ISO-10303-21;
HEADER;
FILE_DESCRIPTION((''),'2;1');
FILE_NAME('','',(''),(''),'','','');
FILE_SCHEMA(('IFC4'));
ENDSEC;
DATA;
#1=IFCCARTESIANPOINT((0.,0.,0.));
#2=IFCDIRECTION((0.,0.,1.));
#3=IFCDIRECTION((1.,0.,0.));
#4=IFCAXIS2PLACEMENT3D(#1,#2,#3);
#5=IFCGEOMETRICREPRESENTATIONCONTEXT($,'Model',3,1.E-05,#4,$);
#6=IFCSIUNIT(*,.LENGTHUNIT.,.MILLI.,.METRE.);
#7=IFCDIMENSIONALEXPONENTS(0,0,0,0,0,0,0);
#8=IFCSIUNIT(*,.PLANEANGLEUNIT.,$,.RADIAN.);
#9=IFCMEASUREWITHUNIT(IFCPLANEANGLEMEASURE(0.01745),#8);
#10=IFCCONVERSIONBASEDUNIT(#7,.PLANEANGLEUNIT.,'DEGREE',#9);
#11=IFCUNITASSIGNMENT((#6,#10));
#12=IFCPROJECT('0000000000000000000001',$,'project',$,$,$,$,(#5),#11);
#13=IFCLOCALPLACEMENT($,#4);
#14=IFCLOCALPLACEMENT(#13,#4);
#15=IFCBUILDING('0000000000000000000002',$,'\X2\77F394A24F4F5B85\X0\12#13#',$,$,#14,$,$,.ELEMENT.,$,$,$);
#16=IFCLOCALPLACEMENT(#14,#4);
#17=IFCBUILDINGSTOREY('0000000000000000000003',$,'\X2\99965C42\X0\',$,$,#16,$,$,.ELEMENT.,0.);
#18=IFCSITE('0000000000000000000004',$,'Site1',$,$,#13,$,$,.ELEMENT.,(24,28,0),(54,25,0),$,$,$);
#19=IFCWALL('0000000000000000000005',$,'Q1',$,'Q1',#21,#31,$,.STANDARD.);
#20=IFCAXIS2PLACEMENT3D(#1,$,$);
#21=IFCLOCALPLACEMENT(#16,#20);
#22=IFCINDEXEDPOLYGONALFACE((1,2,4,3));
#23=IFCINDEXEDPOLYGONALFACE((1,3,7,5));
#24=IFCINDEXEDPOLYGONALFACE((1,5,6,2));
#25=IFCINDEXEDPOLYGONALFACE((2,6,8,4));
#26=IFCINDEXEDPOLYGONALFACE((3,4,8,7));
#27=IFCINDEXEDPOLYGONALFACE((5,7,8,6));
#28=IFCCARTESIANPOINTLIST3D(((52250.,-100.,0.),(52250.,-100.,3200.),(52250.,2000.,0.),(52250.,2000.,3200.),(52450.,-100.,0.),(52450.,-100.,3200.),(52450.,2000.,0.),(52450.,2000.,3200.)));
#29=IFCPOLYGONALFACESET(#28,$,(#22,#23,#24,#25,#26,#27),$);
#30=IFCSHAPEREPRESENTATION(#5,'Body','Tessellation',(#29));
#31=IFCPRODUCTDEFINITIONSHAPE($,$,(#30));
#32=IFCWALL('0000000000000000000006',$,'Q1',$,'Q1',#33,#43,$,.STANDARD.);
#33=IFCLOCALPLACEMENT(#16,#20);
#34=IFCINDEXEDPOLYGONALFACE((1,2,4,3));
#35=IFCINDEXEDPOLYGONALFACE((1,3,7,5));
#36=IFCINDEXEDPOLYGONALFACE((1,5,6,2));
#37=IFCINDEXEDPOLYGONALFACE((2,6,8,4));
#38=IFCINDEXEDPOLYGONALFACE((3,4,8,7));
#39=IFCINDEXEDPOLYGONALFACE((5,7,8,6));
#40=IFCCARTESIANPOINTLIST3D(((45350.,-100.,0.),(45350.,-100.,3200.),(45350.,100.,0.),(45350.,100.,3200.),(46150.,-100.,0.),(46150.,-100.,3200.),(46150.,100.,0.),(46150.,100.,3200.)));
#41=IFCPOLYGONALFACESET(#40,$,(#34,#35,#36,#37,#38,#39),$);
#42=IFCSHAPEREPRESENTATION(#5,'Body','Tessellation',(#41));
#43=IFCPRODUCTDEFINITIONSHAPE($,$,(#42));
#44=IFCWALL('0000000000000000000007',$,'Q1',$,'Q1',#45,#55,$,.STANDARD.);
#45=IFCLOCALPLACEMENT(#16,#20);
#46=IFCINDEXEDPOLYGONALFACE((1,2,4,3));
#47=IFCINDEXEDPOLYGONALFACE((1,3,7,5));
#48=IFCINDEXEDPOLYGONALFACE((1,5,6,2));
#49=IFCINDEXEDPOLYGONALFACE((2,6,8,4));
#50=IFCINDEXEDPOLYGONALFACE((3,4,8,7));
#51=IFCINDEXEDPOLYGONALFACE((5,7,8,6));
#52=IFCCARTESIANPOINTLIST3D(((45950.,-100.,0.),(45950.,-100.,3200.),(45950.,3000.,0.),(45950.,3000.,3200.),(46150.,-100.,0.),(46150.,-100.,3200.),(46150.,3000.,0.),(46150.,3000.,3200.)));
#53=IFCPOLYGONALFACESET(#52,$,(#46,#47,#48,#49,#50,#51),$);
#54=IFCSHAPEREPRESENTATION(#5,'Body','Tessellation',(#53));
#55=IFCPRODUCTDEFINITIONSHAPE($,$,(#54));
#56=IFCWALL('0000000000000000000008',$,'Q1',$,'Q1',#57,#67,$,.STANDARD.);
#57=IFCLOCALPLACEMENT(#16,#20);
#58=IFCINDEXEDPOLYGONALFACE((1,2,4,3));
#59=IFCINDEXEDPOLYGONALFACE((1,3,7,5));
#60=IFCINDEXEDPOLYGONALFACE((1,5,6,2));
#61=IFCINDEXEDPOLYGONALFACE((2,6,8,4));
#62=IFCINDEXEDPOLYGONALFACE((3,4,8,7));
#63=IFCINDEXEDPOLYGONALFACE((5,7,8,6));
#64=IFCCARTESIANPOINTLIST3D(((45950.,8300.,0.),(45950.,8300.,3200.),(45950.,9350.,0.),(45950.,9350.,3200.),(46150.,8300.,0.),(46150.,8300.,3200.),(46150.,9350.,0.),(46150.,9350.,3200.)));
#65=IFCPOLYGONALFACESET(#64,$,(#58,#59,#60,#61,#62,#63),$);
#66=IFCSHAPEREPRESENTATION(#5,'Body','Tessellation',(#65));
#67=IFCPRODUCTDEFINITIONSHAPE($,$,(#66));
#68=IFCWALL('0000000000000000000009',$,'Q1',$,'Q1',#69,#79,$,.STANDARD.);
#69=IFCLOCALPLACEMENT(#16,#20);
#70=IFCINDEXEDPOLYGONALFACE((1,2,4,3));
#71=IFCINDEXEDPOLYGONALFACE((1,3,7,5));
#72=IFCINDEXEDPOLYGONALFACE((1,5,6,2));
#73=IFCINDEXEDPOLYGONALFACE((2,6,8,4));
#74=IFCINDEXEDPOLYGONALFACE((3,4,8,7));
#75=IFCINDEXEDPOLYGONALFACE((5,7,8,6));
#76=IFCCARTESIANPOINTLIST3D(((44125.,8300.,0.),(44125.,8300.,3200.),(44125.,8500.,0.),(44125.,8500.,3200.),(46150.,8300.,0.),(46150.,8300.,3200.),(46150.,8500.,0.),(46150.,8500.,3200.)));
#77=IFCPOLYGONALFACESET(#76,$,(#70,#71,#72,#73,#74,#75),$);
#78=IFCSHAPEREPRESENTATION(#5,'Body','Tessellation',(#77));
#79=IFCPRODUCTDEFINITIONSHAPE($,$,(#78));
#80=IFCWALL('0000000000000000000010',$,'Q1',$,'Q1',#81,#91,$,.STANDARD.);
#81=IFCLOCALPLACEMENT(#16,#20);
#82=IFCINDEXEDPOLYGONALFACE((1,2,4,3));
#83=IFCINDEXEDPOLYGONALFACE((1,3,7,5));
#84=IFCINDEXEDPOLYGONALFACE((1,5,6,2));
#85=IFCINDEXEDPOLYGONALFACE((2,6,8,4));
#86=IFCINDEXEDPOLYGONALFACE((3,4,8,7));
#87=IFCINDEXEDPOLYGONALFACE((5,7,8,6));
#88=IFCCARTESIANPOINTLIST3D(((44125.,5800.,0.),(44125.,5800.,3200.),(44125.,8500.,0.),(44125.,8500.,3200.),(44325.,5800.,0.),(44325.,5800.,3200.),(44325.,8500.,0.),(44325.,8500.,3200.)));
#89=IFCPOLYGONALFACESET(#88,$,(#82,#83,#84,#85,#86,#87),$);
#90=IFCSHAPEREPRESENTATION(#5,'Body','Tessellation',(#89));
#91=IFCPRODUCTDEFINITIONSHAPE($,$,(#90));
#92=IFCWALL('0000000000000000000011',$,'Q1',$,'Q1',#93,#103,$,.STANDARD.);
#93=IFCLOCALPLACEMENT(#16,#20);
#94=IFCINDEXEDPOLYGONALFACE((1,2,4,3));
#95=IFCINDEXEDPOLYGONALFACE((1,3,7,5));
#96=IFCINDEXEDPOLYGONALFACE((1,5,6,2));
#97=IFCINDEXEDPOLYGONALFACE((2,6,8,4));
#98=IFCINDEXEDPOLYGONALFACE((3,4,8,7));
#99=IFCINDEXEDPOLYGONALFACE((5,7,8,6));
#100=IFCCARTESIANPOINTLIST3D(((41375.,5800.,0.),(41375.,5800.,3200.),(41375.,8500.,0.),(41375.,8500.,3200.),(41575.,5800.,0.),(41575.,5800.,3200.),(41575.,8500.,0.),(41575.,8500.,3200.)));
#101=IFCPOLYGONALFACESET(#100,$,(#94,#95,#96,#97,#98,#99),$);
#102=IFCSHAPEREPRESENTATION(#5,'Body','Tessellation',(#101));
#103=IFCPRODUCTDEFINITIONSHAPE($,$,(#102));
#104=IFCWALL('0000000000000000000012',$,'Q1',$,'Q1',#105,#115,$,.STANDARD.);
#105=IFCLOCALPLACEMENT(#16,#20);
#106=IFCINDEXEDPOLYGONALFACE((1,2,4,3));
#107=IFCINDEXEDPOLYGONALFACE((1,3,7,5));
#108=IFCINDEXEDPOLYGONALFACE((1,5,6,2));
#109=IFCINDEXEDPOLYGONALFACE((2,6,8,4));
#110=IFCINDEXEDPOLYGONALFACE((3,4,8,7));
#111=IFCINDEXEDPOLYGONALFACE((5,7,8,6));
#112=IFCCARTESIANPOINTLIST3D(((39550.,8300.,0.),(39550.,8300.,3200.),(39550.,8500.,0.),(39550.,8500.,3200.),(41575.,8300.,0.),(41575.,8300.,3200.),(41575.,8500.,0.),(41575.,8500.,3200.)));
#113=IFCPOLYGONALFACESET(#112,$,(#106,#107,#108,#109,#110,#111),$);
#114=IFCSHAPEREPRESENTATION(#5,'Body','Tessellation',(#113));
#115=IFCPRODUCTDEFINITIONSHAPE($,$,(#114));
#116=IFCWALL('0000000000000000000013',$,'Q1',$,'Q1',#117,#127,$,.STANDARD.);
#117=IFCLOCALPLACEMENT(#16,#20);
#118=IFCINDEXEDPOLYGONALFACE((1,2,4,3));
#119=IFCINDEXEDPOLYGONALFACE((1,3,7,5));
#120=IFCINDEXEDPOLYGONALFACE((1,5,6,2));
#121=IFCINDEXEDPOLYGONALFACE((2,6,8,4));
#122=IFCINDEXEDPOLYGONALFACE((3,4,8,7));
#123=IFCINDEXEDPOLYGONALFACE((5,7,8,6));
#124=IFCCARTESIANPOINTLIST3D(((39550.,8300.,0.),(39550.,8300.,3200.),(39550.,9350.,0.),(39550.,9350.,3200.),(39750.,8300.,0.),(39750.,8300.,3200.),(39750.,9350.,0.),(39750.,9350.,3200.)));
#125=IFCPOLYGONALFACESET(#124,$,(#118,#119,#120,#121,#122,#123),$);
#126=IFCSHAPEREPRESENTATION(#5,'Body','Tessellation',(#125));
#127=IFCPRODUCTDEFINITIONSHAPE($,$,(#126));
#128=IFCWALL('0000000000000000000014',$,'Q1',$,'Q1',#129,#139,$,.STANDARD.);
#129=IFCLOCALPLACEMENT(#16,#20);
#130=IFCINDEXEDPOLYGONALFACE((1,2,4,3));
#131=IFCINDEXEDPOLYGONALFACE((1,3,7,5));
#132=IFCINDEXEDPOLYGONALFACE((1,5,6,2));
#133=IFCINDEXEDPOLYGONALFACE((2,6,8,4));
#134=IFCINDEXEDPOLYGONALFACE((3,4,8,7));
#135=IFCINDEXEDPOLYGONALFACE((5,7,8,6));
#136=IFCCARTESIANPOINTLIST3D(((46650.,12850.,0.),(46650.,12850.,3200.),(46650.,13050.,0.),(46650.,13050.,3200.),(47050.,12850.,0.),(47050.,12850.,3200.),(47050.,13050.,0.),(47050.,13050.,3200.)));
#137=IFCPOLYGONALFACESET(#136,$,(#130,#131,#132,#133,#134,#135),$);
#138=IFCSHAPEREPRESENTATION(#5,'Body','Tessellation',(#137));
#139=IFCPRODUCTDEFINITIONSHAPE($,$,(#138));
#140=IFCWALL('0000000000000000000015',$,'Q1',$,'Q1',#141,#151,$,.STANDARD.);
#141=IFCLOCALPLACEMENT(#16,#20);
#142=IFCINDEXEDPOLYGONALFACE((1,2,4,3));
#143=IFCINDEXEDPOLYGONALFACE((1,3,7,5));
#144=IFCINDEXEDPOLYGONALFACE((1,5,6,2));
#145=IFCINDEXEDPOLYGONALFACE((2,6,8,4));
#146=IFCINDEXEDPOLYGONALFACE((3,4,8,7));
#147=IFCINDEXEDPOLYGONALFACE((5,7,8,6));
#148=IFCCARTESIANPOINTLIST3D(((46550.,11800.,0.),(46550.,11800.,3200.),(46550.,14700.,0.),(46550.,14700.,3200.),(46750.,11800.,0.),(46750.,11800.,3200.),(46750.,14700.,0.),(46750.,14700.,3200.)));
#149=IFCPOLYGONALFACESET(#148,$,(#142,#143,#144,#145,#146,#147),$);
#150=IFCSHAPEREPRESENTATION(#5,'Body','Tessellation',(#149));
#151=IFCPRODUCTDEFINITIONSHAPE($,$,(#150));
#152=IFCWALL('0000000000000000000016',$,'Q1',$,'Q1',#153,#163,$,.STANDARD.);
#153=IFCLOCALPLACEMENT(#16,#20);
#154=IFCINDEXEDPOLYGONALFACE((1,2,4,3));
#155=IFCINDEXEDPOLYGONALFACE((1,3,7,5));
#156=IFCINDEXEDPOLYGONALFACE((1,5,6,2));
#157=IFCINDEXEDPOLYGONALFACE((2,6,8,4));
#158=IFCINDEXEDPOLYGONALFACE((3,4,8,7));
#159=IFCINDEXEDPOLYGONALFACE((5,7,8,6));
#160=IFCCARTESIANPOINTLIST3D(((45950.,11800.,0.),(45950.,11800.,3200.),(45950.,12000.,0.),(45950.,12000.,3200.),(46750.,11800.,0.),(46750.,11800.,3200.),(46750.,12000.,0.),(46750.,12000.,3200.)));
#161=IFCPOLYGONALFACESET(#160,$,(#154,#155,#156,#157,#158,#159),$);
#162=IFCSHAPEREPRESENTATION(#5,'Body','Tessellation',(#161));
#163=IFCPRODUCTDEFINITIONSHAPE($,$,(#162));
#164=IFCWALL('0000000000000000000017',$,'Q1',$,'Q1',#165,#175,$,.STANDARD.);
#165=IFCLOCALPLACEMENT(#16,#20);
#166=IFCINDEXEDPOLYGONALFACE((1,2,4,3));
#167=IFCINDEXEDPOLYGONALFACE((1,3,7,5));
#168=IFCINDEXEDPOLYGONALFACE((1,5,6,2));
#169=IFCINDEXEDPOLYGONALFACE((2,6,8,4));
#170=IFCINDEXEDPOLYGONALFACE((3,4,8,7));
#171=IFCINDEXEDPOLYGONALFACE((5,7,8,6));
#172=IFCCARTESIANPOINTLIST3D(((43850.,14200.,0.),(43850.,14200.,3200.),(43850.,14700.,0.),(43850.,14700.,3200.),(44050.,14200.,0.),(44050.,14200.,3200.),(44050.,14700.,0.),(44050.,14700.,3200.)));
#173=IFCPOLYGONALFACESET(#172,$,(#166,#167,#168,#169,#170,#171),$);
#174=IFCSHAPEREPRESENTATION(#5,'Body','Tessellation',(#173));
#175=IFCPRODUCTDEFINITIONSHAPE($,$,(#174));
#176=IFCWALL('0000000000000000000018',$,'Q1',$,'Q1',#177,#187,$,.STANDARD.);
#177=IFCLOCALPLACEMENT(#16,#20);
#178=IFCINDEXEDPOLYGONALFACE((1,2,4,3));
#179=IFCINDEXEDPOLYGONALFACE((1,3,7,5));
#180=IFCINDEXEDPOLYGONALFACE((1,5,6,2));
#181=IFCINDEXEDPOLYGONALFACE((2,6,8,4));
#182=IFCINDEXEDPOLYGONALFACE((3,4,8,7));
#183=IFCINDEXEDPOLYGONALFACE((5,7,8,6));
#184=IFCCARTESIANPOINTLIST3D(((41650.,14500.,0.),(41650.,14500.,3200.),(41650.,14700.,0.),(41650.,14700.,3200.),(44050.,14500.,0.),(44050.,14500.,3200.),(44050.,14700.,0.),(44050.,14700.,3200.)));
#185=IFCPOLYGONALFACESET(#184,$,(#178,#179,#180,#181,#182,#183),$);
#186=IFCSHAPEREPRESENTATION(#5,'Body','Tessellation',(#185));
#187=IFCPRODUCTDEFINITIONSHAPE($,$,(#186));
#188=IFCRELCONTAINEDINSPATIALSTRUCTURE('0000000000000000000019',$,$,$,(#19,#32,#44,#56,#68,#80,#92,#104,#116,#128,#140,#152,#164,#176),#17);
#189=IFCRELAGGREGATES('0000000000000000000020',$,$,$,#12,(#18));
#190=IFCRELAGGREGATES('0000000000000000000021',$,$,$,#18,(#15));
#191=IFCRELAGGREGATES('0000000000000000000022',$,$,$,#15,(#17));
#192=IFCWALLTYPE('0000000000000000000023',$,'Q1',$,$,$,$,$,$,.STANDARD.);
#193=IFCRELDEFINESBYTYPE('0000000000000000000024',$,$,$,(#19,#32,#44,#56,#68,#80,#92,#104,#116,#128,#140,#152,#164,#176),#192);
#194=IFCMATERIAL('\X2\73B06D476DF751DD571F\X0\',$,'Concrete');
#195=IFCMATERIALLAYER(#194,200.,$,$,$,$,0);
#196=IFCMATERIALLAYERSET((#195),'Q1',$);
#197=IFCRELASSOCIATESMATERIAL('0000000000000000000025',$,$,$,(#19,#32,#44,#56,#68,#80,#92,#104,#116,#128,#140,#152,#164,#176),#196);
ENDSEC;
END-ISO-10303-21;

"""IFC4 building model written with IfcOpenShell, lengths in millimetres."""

from ifc_helpers import new_model, entity, si_unit, converted_unit, frame, origin_with_axes, place, context, project, spatial, polyline, outline, extrude, material, layer, layer_set, type_object, element, save


model = new_model("IFC4")

# Units and contexts
model_context = context("Model", 3, precision=1e-05, world=origin_with_axes())
ifc_project = project(units=[si_unit("LENGTHUNIT", "METRE", prefix="MILLI"), converted_unit("PLANEANGLEUNIT", "DEGREE", entity("IfcPlaneAngleMeasure", 0.01745), si_unit("PLANEANGLEUNIT", "RADIAN"), dimensions=[0, 0, 0, 0, 0, 0, 0])], contexts=[model_context])

# Site, building, storey
site_placement = place(None, origin_with_axes())
site = spatial("IfcSite", under=ifc_project, at=site_placement, Name="Site1", CompositionType="ELEMENT", RefLatitude=(24, 28, 0), RefLongitude=(54, 25, 0))
building_placement = place(site_placement, origin_with_axes())
building = spatial("IfcBuilding", under=site, at=building_placement, Name="石钢住宅12#13#", CompositionType="ELEMENT")
storey_placement = place(building_placement, origin_with_axes())
storey = spatial("IfcBuildingStorey", under=building, at=storey_placement, Name="首层", CompositionType="ELEMENT", Elevation=0.0)

# Walls
ifc_material_1 = material(Name="现浇混凝土", Category="Concrete")
ifc_layer = layer(ifc_material_1, 200.0, Priority=0)
ifc_layer_set = layer_set([ifc_layer], Name="Q1")
wall_type = type_object("IfcWallType", Name="Q1", PredefinedType="STANDARD")
wall_1_placement = place(storey_placement, origin_with_axes())
element("IfcWall", 1, at=wall_1_placement, inside=storey, type_object=wall_type, material=ifc_layer_set, Name="Q1", ObjectType="Q1", PredefinedType="STANDARD", context=model_context, shape_type="SweptSolid", body=[
    extrude(outline(polyline([(0.0, 0.0), (3200.0, 0.0), (3200.0, 2100.0), (0.0, 2100.0), (0.0, 0.0)])), frame((52250.0, -100.0, 3200.0), z_axis=(1.0, 0.0, 0.0), x_axis=(0.0, 0.0, -1.0)), (0.0, 0.0, 1.0), 200.0),
])
wall_2_placement = place(storey_placement, origin_with_axes())
element("IfcWall", 2, at=wall_2_placement, inside=storey, type_object=wall_type, material=ifc_layer_set, Name="Q1", ObjectType="Q1", PredefinedType="STANDARD", context=model_context, shape_type="SweptSolid", body=[
    extrude(outline(polyline([(0.0, 0.0), (3200.0, 0.0), (3200.0, 800.0), (0.0, 800.0), (0.0, 0.0)])), frame((45350.0, 100.0, 3200.0), z_axis=(0.0, -1.0, 0.0), x_axis=(0.0, 0.0, -1.0)), (0.0, 0.0, 1.0), 200.0),
])
wall_3_placement = place(storey_placement, origin_with_axes())
element("IfcWall", 3, at=wall_3_placement, inside=storey, type_object=wall_type, material=ifc_layer_set, Name="Q1", ObjectType="Q1", PredefinedType="STANDARD", context=model_context, shape_type="SweptSolid", body=[
    extrude(outline(polyline([(0.0, 0.0), (3200.0, 0.0), (3200.0, 3100.0), (0.0, 3100.0), (0.0, 0.0)])), frame((45950.0, -100.0, 3200.0), z_axis=(1.0, 0.0, 0.0), x_axis=(0.0, 0.0, -1.0)), (0.0, 0.0, 1.0), 200.0),
])
wall_4_placement = place(storey_placement, origin_with_axes())
element("IfcWall", 4, at=wall_4_placement, inside=storey, type_object=wall_type, material=ifc_layer_set, Name="Q1", ObjectType="Q1", PredefinedType="STANDARD", context=model_context, shape_type="SweptSolid", body=[
    extrude(outline(polyline([(0.0, 0.0), (3200.0, 0.0), (3200.0, 1050.0), (0.0, 1050.0), (0.0, 0.0)])), frame((45950.0, 8300.0, 3200.0), z_axis=(1.0, 0.0, 0.0), x_axis=(0.0, 0.0, -1.0)), (0.0, 0.0, 1.0), 200.0),
])
wall_5_placement = place(storey_placement, origin_with_axes())
element("IfcWall", 5, at=wall_5_placement, inside=storey, type_object=wall_type, material=ifc_layer_set, Name="Q1", ObjectType="Q1", PredefinedType="STANDARD", context=model_context, shape_type="SweptSolid", body=[
    extrude(outline(polyline([(0.0, 0.0), (3200.0, 0.0), (3200.0, 2025.0), (0.0, 2025.0), (0.0, 0.0)])), frame((44125.0, 8500.0, 3200.0), z_axis=(0.0, -1.0, 0.0), x_axis=(0.0, 0.0, -1.0)), (0.0, 0.0, 1.0), 200.0),
])
wall_6_placement = place(storey_placement, origin_with_axes())
element("IfcWall", 6, at=wall_6_placement, inside=storey, type_object=wall_type, material=ifc_layer_set, Name="Q1", ObjectType="Q1", PredefinedType="STANDARD", context=model_context, shape_type="SweptSolid", body=[
    extrude(outline(polyline([(0.0, 0.0), (3200.0, 0.0), (3200.0, 2700.0), (0.0, 2700.0), (0.0, 0.0)])), frame((44125.0, 5800.0, 3200.0), z_axis=(1.0, 0.0, 0.0), x_axis=(0.0, 0.0, -1.0)), (0.0, 0.0, 1.0), 200.0),
])
wall_7_placement = place(storey_placement, origin_with_axes())
element("IfcWall", 7, at=wall_7_placement, inside=storey, type_object=wall_type, material=ifc_layer_set, Name="Q1", ObjectType="Q1", PredefinedType="STANDARD", context=model_context, shape_type="SweptSolid", body=[
    extrude(outline(polyline([(0.0, 0.0), (3200.0, 0.0), (3200.0, 2700.0), (0.0, 2700.0), (0.0, 0.0)])), frame((41375.0, 5800.0, 3200.0), z_axis=(1.0, 0.0, 0.0), x_axis=(0.0, 0.0, -1.0)), (0.0, 0.0, 1.0), 200.0),
])
wall_8_placement = place(storey_placement, origin_with_axes())
element("IfcWall", 8, at=wall_8_placement, inside=storey, type_object=wall_type, material=ifc_layer_set, Name="Q1", ObjectType="Q1", PredefinedType="STANDARD", context=model_context, shape_type="SweptSolid", body=[
    extrude(outline(polyline([(0.0, 0.0), (3200.0, 0.0), (3200.0, 2025.0), (0.0, 2025.0), (0.0, 0.0)])), frame((39550.0, 8500.0, 3200.0), z_axis=(0.0, -1.0, 0.0), x_axis=(0.0, 0.0, -1.0)), (0.0, 0.0, 1.0), 200.0),
])
wall_9_placement = place(storey_placement, origin_with_axes())
element("IfcWall", 9, at=wall_9_placement, inside=storey, type_object=wall_type, material=ifc_layer_set, Name="Q1", ObjectType="Q1", PredefinedType="STANDARD", context=model_context, shape_type="SweptSolid", body=[
    extrude(outline(polyline([(0.0, 0.0), (3200.0, 0.0), (3200.0, 1050.0), (0.0, 1050.0), (0.0, 0.0)])), frame((39550.0, 8300.0, 3200.0), z_axis=(1.0, 0.0, 0.0), x_axis=(0.0, 0.0, -1.0)), (0.0, 0.0, 1.0), 200.0),
])
wall_10_placement = place(storey_placement, origin_with_axes())
element("IfcWall", 10, at=wall_10_placement, inside=storey, type_object=wall_type, material=ifc_layer_set, Name="Q1", ObjectType="Q1", PredefinedType="STANDARD", context=model_context, shape_type="SweptSolid", body=[
    extrude(outline(polyline([(0.0, 0.0), (3200.0, 0.0), (3200.0, 400.0), (0.0, 400.0), (0.0, 0.0)])), frame((46650.0, 13050.0, 3200.0), z_axis=(0.0, -1.0, 0.0), x_axis=(0.0, 0.0, -1.0)), (0.0, 0.0, 1.0), 200.0),
])
wall_11_placement = place(storey_placement, origin_with_axes())
element("IfcWall", 11, at=wall_11_placement, inside=storey, type_object=wall_type, material=ifc_layer_set, Name="Q1", ObjectType="Q1", PredefinedType="STANDARD", context=model_context, shape_type="SweptSolid", body=[
    extrude(outline(polyline([(0.0, 0.0), (3200.0, 0.0), (3200.0, 2900.0), (0.0, 2900.0), (0.0, 0.0)])), frame((46550.0, 11800.0, 3200.0), z_axis=(1.0, 0.0, 0.0), x_axis=(0.0, 0.0, -1.0)), (0.0, 0.0, 1.0), 200.0),
])
wall_12_placement = place(storey_placement, origin_with_axes())
element("IfcWall", 12, at=wall_12_placement, inside=storey, type_object=wall_type, material=ifc_layer_set, Name="Q1", ObjectType="Q1", PredefinedType="STANDARD", context=model_context, shape_type="SweptSolid", body=[
    extrude(outline(polyline([(0.0, 0.0), (3200.0, 0.0), (3200.0, 800.0), (0.0, 800.0), (0.0, 0.0)])), frame((45950.0, 12000.0, 3200.0), z_axis=(0.0, -1.0, 0.0), x_axis=(0.0, 0.0, -1.0)), (0.0, 0.0, 1.0), 200.0),
])
wall_13_placement = place(storey_placement, origin_with_axes())
element("IfcWall", 13, at=wall_13_placement, inside=storey, type_object=wall_type, material=ifc_layer_set, Name="Q1", ObjectType="Q1", PredefinedType="STANDARD", context=model_context, shape_type="SweptSolid", body=[
    extrude(outline(polyline([(0.0, 0.0), (3200.0, 0.0), (3200.0, 500.0), (0.0, 500.0), (0.0, 0.0)])), frame((43850.0, 14200.0, 3200.0), z_axis=(1.0, 0.0, 0.0), x_axis=(0.0, 0.0, -1.0)), (0.0, 0.0, 1.0), 200.0),
])
wall_14_placement = place(storey_placement, origin_with_axes())
element("IfcWall", 14, at=wall_14_placement, inside=storey, type_object=wall_type, material=ifc_layer_set, Name="Q1", ObjectType="Q1", PredefinedType="STANDARD", context=model_context, shape_type="SweptSolid", body=[
    extrude(outline(polyline([(0.0, 0.0), (3200.0, 0.0), (3200.0, 2400.0), (0.0, 2400.0), (0.0, 0.0)])), frame((41650.0, 14700.0, 3200.0), z_axis=(0.0, -1.0, 0.0), x_axis=(0.0, 0.0, -1.0)), (0.0, 0.0, 1.0), 200.0),
])

save(model, "model.ifc")
